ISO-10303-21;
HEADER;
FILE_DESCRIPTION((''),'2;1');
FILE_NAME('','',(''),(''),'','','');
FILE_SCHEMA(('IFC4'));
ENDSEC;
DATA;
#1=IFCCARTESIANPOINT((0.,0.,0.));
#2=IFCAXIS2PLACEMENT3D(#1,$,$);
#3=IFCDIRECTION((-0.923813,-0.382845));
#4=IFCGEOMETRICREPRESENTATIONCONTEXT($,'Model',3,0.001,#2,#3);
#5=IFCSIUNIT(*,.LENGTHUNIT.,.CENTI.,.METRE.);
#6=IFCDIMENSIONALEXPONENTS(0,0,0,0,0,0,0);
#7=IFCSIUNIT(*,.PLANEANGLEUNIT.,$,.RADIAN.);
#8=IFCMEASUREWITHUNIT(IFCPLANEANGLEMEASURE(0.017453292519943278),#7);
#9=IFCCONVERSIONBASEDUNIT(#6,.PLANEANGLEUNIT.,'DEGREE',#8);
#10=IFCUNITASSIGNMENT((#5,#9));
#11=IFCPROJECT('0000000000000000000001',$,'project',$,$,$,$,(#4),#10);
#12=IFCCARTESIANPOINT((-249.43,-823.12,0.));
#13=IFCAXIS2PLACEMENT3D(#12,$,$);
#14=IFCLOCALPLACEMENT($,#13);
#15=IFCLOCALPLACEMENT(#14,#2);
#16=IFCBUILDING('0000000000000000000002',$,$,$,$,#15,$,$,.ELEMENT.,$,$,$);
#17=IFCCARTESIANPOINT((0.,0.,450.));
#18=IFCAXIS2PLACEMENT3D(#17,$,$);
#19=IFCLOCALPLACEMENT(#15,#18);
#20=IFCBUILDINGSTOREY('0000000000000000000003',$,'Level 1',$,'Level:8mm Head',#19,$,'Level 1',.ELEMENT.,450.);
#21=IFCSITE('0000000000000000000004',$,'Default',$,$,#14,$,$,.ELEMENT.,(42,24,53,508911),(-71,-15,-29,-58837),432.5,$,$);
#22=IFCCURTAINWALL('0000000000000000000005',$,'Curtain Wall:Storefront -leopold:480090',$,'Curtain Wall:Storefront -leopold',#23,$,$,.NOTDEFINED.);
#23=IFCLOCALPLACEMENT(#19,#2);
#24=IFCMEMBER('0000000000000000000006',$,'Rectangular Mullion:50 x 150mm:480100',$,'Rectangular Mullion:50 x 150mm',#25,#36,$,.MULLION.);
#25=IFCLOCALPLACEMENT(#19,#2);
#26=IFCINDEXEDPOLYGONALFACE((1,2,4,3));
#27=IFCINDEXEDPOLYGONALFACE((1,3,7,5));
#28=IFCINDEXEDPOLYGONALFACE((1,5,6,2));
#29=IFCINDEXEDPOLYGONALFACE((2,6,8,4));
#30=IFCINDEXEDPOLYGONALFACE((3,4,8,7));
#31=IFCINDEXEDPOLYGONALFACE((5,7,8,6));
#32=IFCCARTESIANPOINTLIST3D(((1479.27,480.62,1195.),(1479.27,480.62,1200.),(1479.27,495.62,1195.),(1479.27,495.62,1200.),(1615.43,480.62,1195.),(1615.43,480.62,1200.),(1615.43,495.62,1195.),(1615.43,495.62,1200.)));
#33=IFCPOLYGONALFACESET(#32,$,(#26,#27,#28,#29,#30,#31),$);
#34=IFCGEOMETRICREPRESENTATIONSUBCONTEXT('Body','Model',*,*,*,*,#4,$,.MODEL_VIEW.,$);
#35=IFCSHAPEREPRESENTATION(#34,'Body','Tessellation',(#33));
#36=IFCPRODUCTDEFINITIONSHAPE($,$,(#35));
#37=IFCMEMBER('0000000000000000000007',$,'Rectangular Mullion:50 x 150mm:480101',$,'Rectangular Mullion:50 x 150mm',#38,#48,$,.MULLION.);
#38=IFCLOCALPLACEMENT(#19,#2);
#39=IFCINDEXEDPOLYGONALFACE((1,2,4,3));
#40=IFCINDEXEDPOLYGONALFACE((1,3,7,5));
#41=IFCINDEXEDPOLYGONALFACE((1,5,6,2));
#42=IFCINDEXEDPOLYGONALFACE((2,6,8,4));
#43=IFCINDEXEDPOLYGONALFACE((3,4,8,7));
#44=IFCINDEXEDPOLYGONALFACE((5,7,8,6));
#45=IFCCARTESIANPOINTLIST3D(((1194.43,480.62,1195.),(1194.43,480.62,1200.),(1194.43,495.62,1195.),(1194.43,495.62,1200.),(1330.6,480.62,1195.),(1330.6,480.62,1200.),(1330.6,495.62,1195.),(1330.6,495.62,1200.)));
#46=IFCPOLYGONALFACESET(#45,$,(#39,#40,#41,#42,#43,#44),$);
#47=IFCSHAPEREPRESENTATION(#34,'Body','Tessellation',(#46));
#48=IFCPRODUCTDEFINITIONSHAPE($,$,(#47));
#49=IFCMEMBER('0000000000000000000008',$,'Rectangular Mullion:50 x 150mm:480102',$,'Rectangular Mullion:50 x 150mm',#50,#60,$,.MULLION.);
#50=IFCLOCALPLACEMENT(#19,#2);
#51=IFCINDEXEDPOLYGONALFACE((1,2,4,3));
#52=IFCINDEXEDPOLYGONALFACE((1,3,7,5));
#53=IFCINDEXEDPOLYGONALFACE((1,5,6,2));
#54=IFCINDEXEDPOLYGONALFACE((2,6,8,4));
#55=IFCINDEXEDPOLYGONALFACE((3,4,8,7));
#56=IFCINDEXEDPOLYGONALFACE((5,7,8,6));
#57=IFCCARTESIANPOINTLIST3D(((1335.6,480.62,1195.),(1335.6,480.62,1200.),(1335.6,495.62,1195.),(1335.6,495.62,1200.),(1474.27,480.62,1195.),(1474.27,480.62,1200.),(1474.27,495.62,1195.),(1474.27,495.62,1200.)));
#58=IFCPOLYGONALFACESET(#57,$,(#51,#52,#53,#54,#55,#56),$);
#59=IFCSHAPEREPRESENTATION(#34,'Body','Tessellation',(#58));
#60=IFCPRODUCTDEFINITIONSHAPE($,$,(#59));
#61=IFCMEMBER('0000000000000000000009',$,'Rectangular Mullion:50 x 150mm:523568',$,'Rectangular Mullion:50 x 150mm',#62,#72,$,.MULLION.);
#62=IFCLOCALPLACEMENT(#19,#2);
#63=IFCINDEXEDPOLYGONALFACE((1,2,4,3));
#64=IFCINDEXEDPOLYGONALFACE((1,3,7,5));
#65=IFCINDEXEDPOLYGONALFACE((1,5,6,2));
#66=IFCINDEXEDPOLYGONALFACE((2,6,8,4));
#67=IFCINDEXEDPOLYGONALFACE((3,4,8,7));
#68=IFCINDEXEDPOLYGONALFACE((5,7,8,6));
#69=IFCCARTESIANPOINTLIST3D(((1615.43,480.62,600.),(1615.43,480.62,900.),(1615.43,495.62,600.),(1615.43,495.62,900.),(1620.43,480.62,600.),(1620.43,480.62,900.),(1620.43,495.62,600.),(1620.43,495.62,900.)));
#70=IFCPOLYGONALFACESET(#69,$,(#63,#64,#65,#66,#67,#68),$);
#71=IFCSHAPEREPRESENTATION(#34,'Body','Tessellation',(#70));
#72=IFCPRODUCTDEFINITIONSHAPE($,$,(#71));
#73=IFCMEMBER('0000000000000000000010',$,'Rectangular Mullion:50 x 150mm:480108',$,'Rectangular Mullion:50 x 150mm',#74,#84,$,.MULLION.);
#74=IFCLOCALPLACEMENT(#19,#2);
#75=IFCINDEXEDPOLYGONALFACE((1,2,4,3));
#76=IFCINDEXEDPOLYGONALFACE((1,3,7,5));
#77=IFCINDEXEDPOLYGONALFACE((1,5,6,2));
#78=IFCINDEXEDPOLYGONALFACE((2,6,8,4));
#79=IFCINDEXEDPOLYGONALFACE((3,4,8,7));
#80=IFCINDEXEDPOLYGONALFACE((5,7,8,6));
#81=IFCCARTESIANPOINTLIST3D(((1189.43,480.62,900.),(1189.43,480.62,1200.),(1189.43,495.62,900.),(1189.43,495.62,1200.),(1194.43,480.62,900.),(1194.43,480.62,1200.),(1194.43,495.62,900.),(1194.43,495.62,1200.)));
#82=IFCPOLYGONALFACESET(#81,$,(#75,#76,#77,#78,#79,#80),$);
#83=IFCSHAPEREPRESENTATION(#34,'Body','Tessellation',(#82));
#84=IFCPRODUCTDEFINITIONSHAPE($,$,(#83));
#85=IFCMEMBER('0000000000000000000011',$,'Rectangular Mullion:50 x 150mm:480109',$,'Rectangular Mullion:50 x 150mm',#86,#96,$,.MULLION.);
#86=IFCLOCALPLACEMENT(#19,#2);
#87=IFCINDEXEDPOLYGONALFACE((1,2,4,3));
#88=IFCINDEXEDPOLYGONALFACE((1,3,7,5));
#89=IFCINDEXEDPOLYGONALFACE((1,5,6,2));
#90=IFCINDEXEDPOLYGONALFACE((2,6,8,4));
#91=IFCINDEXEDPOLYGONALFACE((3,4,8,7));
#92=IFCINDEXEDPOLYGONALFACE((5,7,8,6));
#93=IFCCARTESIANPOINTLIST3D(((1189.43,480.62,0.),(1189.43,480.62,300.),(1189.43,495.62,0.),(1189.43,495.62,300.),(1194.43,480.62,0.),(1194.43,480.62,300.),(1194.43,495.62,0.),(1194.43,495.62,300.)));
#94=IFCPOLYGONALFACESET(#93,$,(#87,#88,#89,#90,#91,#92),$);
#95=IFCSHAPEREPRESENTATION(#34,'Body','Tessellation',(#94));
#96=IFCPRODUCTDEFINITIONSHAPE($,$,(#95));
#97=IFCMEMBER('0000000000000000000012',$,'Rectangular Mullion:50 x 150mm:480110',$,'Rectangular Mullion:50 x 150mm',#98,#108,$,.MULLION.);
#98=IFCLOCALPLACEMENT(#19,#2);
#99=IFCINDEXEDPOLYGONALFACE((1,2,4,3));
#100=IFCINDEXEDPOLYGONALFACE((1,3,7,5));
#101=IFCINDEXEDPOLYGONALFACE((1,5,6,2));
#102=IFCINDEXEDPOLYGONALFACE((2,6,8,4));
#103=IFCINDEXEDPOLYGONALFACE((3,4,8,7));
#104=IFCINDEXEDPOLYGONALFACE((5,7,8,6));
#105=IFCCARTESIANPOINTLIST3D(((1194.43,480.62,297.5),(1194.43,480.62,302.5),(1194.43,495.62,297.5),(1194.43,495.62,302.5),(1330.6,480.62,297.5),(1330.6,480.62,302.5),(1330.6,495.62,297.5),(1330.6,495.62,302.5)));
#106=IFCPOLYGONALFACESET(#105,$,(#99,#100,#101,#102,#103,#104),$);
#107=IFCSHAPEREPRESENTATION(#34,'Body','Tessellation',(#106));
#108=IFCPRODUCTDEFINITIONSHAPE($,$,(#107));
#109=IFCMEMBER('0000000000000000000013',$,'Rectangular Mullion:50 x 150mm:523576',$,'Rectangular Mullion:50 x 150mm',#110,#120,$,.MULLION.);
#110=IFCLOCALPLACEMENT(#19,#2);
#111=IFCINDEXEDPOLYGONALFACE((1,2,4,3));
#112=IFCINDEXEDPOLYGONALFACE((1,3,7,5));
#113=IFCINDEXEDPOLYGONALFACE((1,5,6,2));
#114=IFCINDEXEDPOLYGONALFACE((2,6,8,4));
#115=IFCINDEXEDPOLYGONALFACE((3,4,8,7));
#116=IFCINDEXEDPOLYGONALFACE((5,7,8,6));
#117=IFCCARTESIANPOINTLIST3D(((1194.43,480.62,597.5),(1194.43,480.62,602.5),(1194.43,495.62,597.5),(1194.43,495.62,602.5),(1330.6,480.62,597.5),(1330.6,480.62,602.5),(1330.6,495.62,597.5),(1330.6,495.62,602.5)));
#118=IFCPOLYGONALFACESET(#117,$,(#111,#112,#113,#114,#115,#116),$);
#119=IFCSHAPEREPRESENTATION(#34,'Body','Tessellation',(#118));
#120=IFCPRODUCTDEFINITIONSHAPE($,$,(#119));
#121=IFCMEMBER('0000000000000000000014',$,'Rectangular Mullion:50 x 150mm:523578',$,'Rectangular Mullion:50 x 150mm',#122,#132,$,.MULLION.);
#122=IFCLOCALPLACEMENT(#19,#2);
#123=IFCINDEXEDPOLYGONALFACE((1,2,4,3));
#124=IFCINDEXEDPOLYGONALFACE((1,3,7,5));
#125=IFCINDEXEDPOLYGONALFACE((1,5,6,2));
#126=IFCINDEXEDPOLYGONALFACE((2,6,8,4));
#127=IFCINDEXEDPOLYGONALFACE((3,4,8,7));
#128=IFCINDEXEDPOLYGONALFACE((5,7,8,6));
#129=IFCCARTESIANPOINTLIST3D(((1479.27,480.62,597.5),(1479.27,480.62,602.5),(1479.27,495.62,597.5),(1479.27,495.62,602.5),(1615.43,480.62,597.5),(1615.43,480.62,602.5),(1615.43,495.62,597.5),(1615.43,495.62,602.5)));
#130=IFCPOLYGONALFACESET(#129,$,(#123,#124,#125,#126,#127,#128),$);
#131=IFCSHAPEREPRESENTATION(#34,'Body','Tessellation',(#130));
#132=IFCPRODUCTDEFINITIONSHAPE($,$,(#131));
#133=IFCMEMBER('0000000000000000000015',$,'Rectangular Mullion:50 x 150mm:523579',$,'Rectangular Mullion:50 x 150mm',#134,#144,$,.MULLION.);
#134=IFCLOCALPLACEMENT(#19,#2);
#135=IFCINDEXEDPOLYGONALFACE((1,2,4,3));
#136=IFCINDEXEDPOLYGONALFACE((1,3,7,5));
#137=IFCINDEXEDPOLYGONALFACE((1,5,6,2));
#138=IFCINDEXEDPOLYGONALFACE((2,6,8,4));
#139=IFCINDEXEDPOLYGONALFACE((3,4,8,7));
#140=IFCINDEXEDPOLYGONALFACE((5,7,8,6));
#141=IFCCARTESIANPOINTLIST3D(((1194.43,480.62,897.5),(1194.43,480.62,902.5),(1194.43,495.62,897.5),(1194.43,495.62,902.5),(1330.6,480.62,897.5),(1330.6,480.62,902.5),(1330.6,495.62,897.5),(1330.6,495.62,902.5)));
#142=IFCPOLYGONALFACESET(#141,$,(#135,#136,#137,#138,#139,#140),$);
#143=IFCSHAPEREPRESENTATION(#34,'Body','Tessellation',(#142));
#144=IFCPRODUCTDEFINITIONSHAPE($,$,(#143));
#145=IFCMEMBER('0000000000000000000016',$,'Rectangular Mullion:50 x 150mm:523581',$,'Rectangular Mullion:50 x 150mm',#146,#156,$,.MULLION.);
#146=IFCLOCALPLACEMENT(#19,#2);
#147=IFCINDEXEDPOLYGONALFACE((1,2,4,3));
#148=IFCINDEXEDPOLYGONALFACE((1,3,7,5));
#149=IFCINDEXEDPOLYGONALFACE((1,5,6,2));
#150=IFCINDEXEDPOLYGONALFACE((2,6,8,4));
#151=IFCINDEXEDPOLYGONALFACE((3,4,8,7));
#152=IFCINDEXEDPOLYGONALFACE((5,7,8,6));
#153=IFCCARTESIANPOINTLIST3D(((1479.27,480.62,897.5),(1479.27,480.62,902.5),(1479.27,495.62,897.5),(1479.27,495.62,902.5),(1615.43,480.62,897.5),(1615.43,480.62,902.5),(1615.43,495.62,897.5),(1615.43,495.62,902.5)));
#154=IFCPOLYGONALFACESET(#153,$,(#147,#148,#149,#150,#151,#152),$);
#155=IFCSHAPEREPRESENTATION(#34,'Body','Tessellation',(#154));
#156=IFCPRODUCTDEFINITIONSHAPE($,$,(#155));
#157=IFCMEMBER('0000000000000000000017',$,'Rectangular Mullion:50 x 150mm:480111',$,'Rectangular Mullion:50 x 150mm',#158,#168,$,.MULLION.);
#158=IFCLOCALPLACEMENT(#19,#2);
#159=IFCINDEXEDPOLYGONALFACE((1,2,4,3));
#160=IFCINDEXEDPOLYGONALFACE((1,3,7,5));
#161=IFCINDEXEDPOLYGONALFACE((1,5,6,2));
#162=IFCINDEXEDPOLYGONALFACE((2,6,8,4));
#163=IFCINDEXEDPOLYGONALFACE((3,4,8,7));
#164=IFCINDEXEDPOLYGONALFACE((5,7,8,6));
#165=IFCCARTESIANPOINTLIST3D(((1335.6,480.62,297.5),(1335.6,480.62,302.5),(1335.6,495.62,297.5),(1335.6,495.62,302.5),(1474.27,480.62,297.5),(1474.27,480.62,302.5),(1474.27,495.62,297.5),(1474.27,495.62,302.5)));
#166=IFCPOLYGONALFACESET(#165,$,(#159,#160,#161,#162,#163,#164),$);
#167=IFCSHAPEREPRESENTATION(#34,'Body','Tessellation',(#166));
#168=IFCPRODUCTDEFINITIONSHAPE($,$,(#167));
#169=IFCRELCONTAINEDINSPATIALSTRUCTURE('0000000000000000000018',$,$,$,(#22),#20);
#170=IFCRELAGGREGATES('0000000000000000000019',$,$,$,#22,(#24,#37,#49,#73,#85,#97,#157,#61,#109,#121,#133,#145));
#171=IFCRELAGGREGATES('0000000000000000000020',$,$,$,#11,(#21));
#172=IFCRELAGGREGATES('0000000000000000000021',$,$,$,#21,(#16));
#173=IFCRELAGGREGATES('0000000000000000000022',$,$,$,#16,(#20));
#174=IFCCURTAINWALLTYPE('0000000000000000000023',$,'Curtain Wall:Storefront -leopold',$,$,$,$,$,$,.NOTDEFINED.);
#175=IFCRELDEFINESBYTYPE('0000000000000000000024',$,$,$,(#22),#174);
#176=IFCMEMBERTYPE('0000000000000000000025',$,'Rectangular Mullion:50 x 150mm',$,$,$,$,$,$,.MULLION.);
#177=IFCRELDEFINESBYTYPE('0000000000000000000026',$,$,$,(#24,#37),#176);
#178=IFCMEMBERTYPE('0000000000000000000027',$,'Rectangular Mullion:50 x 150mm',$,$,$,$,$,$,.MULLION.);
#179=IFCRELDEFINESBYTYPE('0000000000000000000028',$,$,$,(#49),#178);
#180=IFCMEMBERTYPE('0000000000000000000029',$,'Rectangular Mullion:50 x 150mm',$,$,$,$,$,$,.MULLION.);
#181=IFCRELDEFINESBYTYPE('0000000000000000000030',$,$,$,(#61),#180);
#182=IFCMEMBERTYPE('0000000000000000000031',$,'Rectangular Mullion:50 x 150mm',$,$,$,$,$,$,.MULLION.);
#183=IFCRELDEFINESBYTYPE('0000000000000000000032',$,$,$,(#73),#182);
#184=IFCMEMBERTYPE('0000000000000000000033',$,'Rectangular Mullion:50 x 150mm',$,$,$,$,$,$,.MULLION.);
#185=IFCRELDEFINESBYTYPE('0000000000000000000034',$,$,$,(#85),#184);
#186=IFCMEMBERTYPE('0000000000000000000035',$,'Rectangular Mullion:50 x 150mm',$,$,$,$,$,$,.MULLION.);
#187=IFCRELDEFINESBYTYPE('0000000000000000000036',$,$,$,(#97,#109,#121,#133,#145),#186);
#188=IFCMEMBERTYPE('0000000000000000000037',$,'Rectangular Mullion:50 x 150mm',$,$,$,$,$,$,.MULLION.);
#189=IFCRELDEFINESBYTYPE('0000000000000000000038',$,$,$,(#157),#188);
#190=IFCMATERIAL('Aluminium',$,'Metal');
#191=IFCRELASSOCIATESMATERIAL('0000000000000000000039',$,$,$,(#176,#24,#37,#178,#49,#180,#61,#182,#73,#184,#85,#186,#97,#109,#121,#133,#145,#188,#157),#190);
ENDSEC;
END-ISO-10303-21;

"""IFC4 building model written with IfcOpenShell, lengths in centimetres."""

from ifc_helpers import new_model, entity, si_unit, converted_unit, direction, frame, origin, place, context, subcontext, project, spatial, indexed_curve, outline, extrude, source, transform, mapped, material, type_object, type_shapes, element, aggregate, save


model = new_model("IFC4")

# Units and contexts
model_context = context("Model", 3, precision=0.001, world=origin(), true_north=direction((-0.923813, -0.382845)))
body_context = subcontext(model_context, "Body", "Model", "MODEL_VIEW")
ifc_project = project(units=[si_unit("LENGTHUNIT", "METRE", prefix="CENTI"), converted_unit("PLANEANGLEUNIT", "DEGREE", entity("IfcPlaneAngleMeasure", 0.017453292519943278), si_unit("PLANEANGLEUNIT", "RADIAN"), dimensions=[0, 0, 0, 0, 0, 0, 0])], contexts=[model_context])

# Site, building, storey
site_placement = place(None, frame((-249.43, -823.12, 0.0)))
site = spatial("IfcSite", under=ifc_project, at=site_placement, Name="Default", CompositionType="ELEMENT", RefLatitude=(42, 24, 53, 508911), RefLongitude=(-71, -15, -29, -58837), RefElevation=432.5)
building_placement = place(site_placement, origin())
building = spatial("IfcBuilding", under=site, at=building_placement, CompositionType="ELEMENT")
storey_placement = place(building_placement, frame((0.0, 0.0, 450.0)))
storey = spatial("IfcBuildingStorey", under=building, at=storey_placement, Name="Level 1", ObjectType="Level:8mm Head", LongName="Level 1", CompositionType="ELEMENT", Elevation=450.0)

# Curtain wall, members
curtain_wall_type = type_object("IfcCurtainWallType", Name="Curtain Wall:Storefront -leopold", PredefinedType="NOTDEFINED")
curtain_wall_placement = place(storey_placement, frame((0.0, 0.0, -450.0)))
curtain_wall = element("IfcCurtainWall", 1, at=curtain_wall_placement, inside=storey, type_object=curtain_wall_type, Name="Curtain Wall:Storefront -leopold:480090", ObjectType="Curtain Wall:Storefront -leopold", PredefinedType="NOTDEFINED")
ifc_material_1 = material(Name="Aluminium", Category="Metal")
member_type_1 = type_object("IfcMemberType", Name="Rectangular Mullion:50 x 150mm", PredefinedType="MULLION", material=ifc_material_1)
shared_shape_1 = source(origin(), body_context, "Body", "SweptSolid", [
    extrude(outline(indexed_curve([(-2.5, -7.5), (2.5, -7.5), (2.5, 7.5), (-2.5, 7.5), (-2.5, -7.5)], self_intersect=False)), frame((-2.5, 0.0, -136.17), z_axis=(0.0, 0.0, 1.0), x_axis=(-1.0, 0.0, 0.0)), (0.0, 0.0, 1.0), 136.17),
])
type_shapes(member_type_1, [shared_shape_1])
member_1_placement = place(curtain_wall_placement, frame((1615.43, 488.12, 1650.0), z_axis=(1.0, 0.0, 0.0), x_axis=(0.0, 0.0, 1.0)))
member_1 = element("IfcMember", 2, at=member_1_placement, type_object=member_type_1, material=ifc_material_1, Name="Rectangular Mullion:50 x 150mm:480100", ObjectType="Rectangular Mullion:50 x 150mm", PredefinedType="MULLION", context=body_context, shape_type="MappedRepresentation", body=[
    mapped(shared_shape_1, transform((0.0, 0.0, 0.0), scale=1.0)),
])
member_2_placement = place(curtain_wall_placement, frame((1330.6, 488.12, 1650.0), z_axis=(1.0, 0.0, 0.0), x_axis=(0.0, 0.0, 1.0)))
member_2 = element("IfcMember", 3, at=member_2_placement, type_object=member_type_1, material=ifc_material_1, Name="Rectangular Mullion:50 x 150mm:480101", ObjectType="Rectangular Mullion:50 x 150mm", PredefinedType="MULLION", context=body_context, shape_type="MappedRepresentation", body=[
    mapped(shared_shape_1, transform((0.0, 0.0, 0.0), scale=1.0)),
])
member_type_2 = type_object("IfcMemberType", Name="Rectangular Mullion:50 x 150mm", PredefinedType="MULLION", material=ifc_material_1)
shared_shape_2 = source(origin(), body_context, "Body", "SweptSolid", [
    extrude(outline(indexed_curve([(-2.5, -7.5), (2.5, -7.5), (2.5, 7.5), (-2.5, 7.5), (-2.5, -7.5)], self_intersect=False)), frame((-2.5, 0.0, -138.67), z_axis=(0.0, 0.0, 1.0), x_axis=(-1.0, 0.0, 0.0)), (0.0, 0.0, 1.0), 138.67),
])
type_shapes(member_type_2, [shared_shape_2])
member_3_placement = place(curtain_wall_placement, frame((1474.27, 488.12, 1650.0), z_axis=(1.0, 0.0, 0.0), x_axis=(0.0, 0.0, 1.0)))
member_3 = element("IfcMember", 4, at=member_3_placement, type_object=member_type_2, material=ifc_material_1, Name="Rectangular Mullion:50 x 150mm:480102", ObjectType="Rectangular Mullion:50 x 150mm", PredefinedType="MULLION", context=body_context, shape_type="MappedRepresentation", body=[
    mapped(shared_shape_2, transform((0.0, 0.0, 0.0), scale=1.0)),
])
member_type_3 = type_object("IfcMemberType", Name="Rectangular Mullion:50 x 150mm", PredefinedType="MULLION", material=ifc_material_1)
shared_shape_3 = source(origin(), body_context, "Body", "SweptSolid", [
    extrude(outline(indexed_curve([(-2.5, -7.5), (2.5, -7.5), (2.5, 7.5), (-2.5, 7.5), (-2.5, -7.5)], self_intersect=False)), frame((-2.5, 0.0, -300.0), z_axis=(0.0, 0.0, 1.0), x_axis=(-1.0, 0.0, 0.0)), (0.0, 0.0, 1.0), 300.0),
])
type_shapes(member_type_3, [shared_shape_3])
member_4_placement = place(curtain_wall_placement, frame((1620.43, 488.12, 1050.0), z_axis=(0.0, 0.0, -1.0), x_axis=(1.0, 0.0, 0.0)))
member_4 = element("IfcMember", 5, at=member_4_placement, type_object=member_type_3, material=ifc_material_1, Name="Rectangular Mullion:50 x 150mm:523568", ObjectType="Rectangular Mullion:50 x 150mm", PredefinedType="MULLION", context=body_context, shape_type="MappedRepresentation", body=[
    mapped(shared_shape_3, transform((0.0, 0.0, 0.0), scale=1.0)),
])
member_type_4 = type_object("IfcMemberType", Name="Rectangular Mullion:50 x 150mm", PredefinedType="MULLION", material=ifc_material_1)
shared_shape_4 = source(origin(), body_context, "Body", "SweptSolid", [
    extrude(outline(indexed_curve([(-2.5, -7.5), (2.5, -7.5), (2.5, 7.5), (-2.5, 7.5), (-2.5, -7.5)], self_intersect=False)), frame((-2.5, 0.0, -300.0), z_axis=(0.0, 0.0, 1.0), x_axis=(-1.0, 0.0, 0.0)), (0.0, 0.0, 1.0), 300.0),
])
type_shapes(member_type_4, [shared_shape_4])
member_5_placement = place(curtain_wall_placement, frame((1189.43, 488.12, 1650.0), z_axis=(0.0, 0.0, 1.0), x_axis=(-1.0, 0.0, 0.0)))
member_5 = element("IfcMember", 6, at=member_5_placement, type_object=member_type_4, material=ifc_material_1, Name="Rectangular Mullion:50 x 150mm:480108", ObjectType="Rectangular Mullion:50 x 150mm", PredefinedType="MULLION", context=body_context, shape_type="MappedRepresentation", body=[
    mapped(shared_shape_4, transform((0.0, 0.0, 0.0), scale=1.0)),
])
member_type_5 = type_object("IfcMemberType", Name="Rectangular Mullion:50 x 150mm", PredefinedType="MULLION", material=ifc_material_1)
shared_shape_5 = source(origin(), body_context, "Body", "SweptSolid", [
    extrude(outline(indexed_curve([(-2.5, -7.5), (2.5, -7.5), (2.5, 7.5), (-2.5, 7.5), (-2.5, -7.5)], self_intersect=False)), frame((-2.5, 0.0, -300.0), z_axis=(0.0, 0.0, 1.0), x_axis=(-1.0, 0.0, 0.0)), (0.0, 0.0, 1.0), 300.0),
])
type_shapes(member_type_5, [shared_shape_5])
member_6_placement = place(curtain_wall_placement, frame((1189.43, 488.12, 750.0), z_axis=(0.0, 0.0, 1.0), x_axis=(-1.0, 0.0, 0.0)))
member_6 = element("IfcMember", 7, at=member_6_placement, type_object=member_type_5, material=ifc_material_1, Name="Rectangular Mullion:50 x 150mm:480109", ObjectType="Rectangular Mullion:50 x 150mm", PredefinedType="MULLION", context=body_context, shape_type="MappedRepresentation", body=[
    mapped(shared_shape_5, transform((0.0, 0.0, 0.0), scale=1.0)),
])
member_type_6 = type_object("IfcMemberType", Name="Rectangular Mullion:50 x 150mm", PredefinedType="MULLION", material=ifc_material_1)
shared_shape_6 = source(origin(), body_context, "Body", "SweptSolid", [
    extrude(outline(indexed_curve([(-2.5, -7.5), (2.5, -7.5), (2.5, 7.5), (-2.5, 7.5), (-2.5, -7.5)], self_intersect=False)), frame((0.0, 0.0, -136.17), z_axis=(0.0, 0.0, 1.0), x_axis=(-1.0, 0.0, 0.0)), (0.0, 0.0, 1.0), 136.17),
])
type_shapes(member_type_6, [shared_shape_6])
member_7_placement = place(curtain_wall_placement, frame((1330.6, 488.12, 750.0), z_axis=(1.0, 0.0, 0.0), x_axis=(0.0, 0.0, 1.0)))
member_7 = element("IfcMember", 8, at=member_7_placement, type_object=member_type_6, material=ifc_material_1, Name="Rectangular Mullion:50 x 150mm:480110", ObjectType="Rectangular Mullion:50 x 150mm", PredefinedType="MULLION", context=body_context, shape_type="MappedRepresentation", body=[
    mapped(shared_shape_6, transform((0.0, 0.0, 0.0), scale=1.0)),
])
member_8_placement = place(curtain_wall_placement, frame((1330.6, 488.12, 1050.0), z_axis=(1.0, 0.0, 0.0), x_axis=(0.0, 0.0, 1.0)))
member_8 = element("IfcMember", 9, at=member_8_placement, type_object=member_type_6, material=ifc_material_1, Name="Rectangular Mullion:50 x 150mm:523576", ObjectType="Rectangular Mullion:50 x 150mm", PredefinedType="MULLION", context=body_context, shape_type="MappedRepresentation", body=[
    mapped(shared_shape_6, transform((0.0, 0.0, 0.0), scale=1.0)),
])
member_9_placement = place(curtain_wall_placement, frame((1615.43, 488.12, 1050.0), z_axis=(1.0, 0.0, 0.0), x_axis=(0.0, 0.0, 1.0)))
member_9 = element("IfcMember", 10, at=member_9_placement, type_object=member_type_6, material=ifc_material_1, Name="Rectangular Mullion:50 x 150mm:523578", ObjectType="Rectangular Mullion:50 x 150mm", PredefinedType="MULLION", context=body_context, shape_type="MappedRepresentation", body=[
    mapped(shared_shape_6, transform((0.0, 0.0, 0.0), scale=1.0)),
])
member_10_placement = place(curtain_wall_placement, frame((1330.6, 488.12, 1350.0), z_axis=(1.0, 0.0, 0.0), x_axis=(0.0, 0.0, 1.0)))
member_10 = element("IfcMember", 11, at=member_10_placement, type_object=member_type_6, material=ifc_material_1, Name="Rectangular Mullion:50 x 150mm:523579", ObjectType="Rectangular Mullion:50 x 150mm", PredefinedType="MULLION", context=body_context, shape_type="MappedRepresentation", body=[
    mapped(shared_shape_6, transform((0.0, 0.0, 0.0), scale=1.0)),
])
member_11_placement = place(curtain_wall_placement, frame((1615.43, 488.12, 1350.0), z_axis=(1.0, 0.0, 0.0), x_axis=(0.0, 0.0, 1.0)))
member_11 = element("IfcMember", 12, at=member_11_placement, type_object=member_type_6, material=ifc_material_1, Name="Rectangular Mullion:50 x 150mm:523581", ObjectType="Rectangular Mullion:50 x 150mm", PredefinedType="MULLION", context=body_context, shape_type="MappedRepresentation", body=[
    mapped(shared_shape_6, transform((0.0, 0.0, 0.0), scale=1.0)),
])
member_type_7 = type_object("IfcMemberType", Name="Rectangular Mullion:50 x 150mm", PredefinedType="MULLION", material=ifc_material_1)
shared_shape_7 = source(origin(), body_context, "Body", "SweptSolid", [
    extrude(outline(indexed_curve([(-2.5, -7.5), (2.5, -7.5), (2.5, 7.5), (-2.5, 7.5), (-2.5, -7.5)], self_intersect=False)), frame((0.0, 0.0, -138.67), z_axis=(0.0, 0.0, 1.0), x_axis=(-1.0, 0.0, 0.0)), (0.0, 0.0, 1.0), 138.67),
])
type_shapes(member_type_7, [shared_shape_7])
member_12_placement = place(curtain_wall_placement, frame((1474.27, 488.12, 750.0), z_axis=(1.0, 0.0, 0.0), x_axis=(0.0, 0.0, 1.0)))
member_12 = element("IfcMember", 13, at=member_12_placement, type_object=member_type_7, material=ifc_material_1, Name="Rectangular Mullion:50 x 150mm:480111", ObjectType="Rectangular Mullion:50 x 150mm", PredefinedType="MULLION", context=body_context, shape_type="MappedRepresentation", body=[
    mapped(shared_shape_7, transform((0.0, 0.0, 0.0), scale=1.0)),
])
aggregate(curtain_wall, [member_1, member_2, member_3, member_5, member_6, member_7, member_12, member_4, member_8, member_9, member_10, member_11])

save(model, "model.ifc")
